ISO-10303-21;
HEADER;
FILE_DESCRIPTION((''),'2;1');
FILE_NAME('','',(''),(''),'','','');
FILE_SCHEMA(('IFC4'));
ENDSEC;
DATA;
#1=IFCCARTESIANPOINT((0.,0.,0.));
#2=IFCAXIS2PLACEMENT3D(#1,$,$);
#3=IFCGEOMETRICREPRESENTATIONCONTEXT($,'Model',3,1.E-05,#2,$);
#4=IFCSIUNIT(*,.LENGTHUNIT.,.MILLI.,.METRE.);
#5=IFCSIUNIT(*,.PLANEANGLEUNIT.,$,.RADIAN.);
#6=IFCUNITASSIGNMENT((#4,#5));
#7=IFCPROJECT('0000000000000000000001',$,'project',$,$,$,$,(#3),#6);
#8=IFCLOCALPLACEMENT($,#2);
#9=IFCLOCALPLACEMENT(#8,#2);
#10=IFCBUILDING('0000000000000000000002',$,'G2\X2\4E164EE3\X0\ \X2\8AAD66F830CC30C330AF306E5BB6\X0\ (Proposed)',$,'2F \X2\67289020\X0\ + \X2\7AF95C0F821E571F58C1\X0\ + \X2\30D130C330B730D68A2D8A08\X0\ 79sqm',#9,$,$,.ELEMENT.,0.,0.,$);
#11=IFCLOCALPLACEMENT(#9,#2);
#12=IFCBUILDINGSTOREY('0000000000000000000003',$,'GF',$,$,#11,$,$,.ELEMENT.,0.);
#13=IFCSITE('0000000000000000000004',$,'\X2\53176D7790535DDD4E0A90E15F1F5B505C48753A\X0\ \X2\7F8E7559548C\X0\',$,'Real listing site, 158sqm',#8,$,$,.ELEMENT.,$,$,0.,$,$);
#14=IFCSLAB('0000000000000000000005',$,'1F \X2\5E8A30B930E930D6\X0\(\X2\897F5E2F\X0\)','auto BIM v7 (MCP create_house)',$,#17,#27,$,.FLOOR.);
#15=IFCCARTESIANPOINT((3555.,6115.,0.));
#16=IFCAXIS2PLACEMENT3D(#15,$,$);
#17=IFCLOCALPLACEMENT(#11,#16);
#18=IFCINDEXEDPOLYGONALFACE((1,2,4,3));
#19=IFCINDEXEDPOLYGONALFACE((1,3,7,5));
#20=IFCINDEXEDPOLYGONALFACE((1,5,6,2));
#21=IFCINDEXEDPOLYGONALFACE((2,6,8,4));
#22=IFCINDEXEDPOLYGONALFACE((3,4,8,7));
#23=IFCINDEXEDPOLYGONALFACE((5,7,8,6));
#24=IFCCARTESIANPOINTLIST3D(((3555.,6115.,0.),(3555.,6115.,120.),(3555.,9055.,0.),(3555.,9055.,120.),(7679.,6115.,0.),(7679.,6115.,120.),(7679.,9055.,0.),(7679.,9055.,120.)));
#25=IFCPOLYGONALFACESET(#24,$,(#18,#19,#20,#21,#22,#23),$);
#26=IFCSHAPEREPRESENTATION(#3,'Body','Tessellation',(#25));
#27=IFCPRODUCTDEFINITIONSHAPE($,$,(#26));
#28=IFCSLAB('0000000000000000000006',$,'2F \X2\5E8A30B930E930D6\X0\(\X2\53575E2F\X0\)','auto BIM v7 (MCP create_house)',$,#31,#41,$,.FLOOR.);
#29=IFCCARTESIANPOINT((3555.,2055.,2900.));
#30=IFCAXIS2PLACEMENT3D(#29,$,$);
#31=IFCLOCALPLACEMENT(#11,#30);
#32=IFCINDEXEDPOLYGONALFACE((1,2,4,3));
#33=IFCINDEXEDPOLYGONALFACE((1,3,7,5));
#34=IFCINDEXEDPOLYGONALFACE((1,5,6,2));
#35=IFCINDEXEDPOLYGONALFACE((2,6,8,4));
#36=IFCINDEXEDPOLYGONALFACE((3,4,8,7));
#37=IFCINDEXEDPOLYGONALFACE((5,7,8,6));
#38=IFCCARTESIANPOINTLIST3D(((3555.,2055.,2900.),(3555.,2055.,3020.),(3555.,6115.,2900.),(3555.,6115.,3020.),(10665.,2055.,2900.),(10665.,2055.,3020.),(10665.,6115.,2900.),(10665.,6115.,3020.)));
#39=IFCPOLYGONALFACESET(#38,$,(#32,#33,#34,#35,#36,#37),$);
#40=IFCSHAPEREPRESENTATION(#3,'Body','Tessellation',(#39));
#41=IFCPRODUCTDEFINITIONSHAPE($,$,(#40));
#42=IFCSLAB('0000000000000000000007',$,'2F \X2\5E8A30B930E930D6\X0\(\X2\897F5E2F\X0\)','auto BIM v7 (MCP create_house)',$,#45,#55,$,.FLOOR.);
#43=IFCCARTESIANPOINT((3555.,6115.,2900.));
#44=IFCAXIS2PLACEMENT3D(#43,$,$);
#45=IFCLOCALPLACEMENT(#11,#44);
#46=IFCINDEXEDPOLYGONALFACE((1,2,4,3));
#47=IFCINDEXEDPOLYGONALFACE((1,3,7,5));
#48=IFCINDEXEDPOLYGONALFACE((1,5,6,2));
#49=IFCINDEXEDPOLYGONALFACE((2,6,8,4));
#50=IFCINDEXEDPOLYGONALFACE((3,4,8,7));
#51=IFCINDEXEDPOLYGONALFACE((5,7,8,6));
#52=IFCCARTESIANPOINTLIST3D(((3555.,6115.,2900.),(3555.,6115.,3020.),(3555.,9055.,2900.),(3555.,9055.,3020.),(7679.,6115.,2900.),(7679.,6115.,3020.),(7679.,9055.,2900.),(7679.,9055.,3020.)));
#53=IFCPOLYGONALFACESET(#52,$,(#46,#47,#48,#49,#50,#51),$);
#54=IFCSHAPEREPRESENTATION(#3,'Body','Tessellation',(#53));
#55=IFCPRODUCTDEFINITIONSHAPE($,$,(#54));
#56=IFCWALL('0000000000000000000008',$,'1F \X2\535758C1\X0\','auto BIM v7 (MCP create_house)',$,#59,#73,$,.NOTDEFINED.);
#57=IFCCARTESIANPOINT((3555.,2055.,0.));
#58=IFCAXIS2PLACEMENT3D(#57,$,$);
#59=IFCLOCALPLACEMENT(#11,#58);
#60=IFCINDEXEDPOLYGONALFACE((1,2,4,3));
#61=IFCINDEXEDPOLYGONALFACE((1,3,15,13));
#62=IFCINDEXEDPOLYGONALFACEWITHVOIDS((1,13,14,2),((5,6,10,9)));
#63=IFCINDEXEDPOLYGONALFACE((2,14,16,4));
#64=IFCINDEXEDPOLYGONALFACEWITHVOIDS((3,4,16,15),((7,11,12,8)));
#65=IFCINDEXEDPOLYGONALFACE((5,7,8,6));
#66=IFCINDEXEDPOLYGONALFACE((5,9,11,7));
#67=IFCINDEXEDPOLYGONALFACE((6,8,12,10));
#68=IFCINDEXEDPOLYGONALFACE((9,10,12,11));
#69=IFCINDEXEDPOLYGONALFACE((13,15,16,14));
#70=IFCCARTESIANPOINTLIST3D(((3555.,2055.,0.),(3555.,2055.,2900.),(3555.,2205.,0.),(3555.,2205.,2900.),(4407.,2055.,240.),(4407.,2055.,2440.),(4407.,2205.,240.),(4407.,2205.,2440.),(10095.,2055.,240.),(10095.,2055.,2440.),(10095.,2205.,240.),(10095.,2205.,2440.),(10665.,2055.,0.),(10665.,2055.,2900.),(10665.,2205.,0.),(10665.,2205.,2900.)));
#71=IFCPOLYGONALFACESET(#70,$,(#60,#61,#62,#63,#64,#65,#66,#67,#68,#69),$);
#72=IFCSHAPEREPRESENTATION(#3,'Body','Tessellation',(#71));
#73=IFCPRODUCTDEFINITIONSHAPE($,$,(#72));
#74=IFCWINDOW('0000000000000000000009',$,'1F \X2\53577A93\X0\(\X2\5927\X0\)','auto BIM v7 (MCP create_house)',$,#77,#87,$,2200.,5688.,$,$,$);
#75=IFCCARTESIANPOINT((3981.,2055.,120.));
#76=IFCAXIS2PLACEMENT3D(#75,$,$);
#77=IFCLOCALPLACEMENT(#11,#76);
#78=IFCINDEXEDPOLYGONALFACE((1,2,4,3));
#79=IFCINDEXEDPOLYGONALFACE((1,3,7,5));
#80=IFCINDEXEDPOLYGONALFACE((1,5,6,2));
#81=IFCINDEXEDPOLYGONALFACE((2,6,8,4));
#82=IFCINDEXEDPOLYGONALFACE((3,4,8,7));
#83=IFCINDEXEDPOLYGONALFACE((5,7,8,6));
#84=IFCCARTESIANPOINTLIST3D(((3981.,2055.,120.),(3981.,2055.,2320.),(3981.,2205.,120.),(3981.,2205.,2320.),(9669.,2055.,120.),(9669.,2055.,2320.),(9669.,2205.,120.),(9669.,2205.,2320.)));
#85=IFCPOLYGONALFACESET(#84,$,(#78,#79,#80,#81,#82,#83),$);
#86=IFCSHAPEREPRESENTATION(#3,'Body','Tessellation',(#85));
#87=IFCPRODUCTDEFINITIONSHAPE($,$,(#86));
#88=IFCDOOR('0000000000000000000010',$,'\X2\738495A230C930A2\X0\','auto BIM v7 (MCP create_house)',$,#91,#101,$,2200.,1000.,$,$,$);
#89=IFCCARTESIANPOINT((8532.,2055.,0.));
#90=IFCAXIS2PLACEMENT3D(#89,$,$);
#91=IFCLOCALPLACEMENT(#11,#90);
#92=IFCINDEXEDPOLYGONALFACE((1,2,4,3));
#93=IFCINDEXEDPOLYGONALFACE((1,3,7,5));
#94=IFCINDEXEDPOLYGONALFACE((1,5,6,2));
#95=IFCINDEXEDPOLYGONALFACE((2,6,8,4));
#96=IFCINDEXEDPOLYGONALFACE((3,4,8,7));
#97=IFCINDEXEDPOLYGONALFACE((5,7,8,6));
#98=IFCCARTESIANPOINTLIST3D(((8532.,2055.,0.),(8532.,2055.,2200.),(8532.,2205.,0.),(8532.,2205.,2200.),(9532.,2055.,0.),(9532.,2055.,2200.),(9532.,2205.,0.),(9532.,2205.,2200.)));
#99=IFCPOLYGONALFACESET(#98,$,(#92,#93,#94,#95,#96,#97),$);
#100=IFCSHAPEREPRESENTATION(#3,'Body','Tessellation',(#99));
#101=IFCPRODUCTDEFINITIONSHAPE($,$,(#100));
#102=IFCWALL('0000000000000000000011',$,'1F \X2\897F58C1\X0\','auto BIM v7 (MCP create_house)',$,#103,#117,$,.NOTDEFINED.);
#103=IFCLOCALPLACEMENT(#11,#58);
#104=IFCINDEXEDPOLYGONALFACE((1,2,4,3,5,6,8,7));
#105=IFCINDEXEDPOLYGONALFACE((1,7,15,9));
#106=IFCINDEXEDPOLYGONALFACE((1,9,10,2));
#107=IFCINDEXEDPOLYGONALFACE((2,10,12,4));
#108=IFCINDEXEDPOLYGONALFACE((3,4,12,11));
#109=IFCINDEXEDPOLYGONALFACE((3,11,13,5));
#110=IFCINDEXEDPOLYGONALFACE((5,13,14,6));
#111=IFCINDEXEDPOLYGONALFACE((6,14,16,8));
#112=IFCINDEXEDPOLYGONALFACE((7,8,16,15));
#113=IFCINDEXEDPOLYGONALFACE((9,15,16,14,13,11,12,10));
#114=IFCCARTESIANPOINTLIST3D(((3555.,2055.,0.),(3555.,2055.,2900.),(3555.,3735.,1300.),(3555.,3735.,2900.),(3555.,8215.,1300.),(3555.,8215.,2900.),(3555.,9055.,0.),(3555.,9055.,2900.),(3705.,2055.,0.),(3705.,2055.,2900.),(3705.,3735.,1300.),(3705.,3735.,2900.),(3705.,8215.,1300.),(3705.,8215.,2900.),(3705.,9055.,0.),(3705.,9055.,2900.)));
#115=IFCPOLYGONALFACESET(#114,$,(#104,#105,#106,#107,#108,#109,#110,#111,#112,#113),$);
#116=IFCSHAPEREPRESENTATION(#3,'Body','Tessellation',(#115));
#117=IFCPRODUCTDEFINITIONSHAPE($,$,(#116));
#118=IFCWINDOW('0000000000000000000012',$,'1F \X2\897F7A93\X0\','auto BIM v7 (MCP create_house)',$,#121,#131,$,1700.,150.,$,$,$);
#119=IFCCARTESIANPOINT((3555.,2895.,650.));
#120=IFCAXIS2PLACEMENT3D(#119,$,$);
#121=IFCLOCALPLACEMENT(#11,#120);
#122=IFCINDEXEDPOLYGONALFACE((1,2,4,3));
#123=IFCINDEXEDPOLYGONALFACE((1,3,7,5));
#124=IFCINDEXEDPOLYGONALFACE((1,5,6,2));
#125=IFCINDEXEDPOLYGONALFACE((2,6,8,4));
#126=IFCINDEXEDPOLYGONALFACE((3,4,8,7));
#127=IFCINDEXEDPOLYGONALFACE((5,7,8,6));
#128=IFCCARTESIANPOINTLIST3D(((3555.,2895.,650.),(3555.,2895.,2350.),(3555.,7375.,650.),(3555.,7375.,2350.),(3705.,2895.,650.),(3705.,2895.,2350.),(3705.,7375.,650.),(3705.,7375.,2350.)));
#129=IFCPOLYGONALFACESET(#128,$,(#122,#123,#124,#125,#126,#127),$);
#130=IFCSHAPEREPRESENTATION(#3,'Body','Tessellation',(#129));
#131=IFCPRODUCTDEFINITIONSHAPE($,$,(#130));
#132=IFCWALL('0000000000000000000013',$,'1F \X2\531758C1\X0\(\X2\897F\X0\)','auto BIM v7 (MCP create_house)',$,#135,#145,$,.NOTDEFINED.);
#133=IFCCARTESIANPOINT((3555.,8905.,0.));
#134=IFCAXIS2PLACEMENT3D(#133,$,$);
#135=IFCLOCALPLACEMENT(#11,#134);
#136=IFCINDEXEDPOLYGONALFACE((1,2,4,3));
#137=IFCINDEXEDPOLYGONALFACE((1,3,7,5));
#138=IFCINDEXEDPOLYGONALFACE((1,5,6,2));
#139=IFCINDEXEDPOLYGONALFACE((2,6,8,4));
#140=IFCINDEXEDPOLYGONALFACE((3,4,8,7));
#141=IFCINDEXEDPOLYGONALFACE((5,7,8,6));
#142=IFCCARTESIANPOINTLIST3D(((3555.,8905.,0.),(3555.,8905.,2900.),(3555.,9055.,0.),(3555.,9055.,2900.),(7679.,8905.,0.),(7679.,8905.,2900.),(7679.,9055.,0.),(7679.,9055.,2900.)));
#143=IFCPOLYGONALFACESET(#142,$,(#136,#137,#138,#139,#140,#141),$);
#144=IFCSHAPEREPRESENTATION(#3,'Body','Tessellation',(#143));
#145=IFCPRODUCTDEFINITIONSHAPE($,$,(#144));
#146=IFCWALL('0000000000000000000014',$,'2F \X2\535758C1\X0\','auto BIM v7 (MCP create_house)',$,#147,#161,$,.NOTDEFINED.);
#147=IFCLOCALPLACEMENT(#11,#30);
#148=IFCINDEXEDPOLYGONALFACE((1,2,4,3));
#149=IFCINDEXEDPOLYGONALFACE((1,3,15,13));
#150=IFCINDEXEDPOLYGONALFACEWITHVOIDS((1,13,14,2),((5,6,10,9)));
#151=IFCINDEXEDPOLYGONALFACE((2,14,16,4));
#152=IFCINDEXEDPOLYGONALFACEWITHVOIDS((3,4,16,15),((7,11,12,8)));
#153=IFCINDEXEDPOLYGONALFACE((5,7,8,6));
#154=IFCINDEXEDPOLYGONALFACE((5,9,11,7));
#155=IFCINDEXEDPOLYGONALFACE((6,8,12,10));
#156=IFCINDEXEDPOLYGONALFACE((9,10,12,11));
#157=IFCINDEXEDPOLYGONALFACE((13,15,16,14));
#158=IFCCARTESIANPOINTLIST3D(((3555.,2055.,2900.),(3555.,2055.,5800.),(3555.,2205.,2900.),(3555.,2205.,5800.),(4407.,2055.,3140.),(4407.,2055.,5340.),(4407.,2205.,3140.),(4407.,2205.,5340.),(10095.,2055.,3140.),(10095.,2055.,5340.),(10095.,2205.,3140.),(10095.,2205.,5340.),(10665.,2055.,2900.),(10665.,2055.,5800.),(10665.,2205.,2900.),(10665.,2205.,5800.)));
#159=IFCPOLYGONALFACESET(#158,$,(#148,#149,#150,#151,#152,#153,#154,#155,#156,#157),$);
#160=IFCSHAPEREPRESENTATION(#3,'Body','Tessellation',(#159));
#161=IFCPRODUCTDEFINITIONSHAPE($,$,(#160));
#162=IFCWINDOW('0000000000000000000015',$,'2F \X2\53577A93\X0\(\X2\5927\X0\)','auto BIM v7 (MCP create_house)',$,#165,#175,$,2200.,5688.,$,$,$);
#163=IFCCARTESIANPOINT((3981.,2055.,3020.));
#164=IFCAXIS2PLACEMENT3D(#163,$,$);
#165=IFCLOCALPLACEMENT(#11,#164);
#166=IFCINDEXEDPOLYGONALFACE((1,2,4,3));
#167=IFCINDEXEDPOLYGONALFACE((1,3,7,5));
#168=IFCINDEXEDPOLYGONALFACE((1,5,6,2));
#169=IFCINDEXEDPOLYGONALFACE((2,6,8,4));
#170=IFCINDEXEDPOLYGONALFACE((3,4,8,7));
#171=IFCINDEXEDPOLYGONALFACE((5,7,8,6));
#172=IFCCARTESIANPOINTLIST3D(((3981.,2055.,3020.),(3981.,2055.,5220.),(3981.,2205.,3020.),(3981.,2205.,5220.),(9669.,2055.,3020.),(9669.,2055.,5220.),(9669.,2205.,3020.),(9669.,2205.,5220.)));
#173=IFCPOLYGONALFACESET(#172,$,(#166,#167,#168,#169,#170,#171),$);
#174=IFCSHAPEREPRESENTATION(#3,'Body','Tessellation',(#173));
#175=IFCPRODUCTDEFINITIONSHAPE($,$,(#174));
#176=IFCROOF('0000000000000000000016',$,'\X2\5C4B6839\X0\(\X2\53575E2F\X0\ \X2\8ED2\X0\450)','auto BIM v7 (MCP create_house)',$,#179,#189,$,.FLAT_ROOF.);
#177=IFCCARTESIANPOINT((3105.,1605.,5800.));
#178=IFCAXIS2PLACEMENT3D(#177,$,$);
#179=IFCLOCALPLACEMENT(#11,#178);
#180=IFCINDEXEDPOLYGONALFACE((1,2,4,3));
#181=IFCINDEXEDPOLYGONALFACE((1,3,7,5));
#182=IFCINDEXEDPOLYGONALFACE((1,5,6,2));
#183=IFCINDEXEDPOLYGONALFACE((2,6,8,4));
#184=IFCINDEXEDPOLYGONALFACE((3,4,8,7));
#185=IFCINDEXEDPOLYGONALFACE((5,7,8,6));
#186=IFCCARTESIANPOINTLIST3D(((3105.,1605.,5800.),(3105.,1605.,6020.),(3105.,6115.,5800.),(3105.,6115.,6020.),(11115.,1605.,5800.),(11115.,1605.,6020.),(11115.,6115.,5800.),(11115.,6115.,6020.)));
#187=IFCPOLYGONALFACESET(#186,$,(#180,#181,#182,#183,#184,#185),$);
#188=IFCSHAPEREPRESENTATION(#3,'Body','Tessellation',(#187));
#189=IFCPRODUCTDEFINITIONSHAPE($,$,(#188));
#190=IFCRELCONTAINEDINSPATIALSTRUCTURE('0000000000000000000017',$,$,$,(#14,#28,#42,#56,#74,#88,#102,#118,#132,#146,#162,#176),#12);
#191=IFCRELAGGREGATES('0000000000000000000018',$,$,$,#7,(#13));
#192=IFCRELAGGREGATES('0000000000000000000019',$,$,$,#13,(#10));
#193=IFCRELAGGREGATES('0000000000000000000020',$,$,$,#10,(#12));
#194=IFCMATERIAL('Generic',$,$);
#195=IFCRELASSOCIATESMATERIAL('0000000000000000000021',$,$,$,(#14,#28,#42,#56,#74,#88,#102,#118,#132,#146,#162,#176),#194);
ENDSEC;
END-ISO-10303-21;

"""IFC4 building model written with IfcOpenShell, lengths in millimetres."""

from ifc_helpers import new_model, si_unit, frame, frame_2d, origin, place, context, project, spatial, rectangle, extrude, material, element, fill, save


model = new_model("IFC4")

# Units and contexts
model_context = context("Model", 3, precision=1e-05, world=origin())
ifc_project = project(units=[si_unit("LENGTHUNIT", "METRE", prefix="MILLI"), si_unit("PLANEANGLEUNIT", "RADIAN")], contexts=[model_context])

# Site, building, storey
site_placement = place(None, origin())
site = spatial("IfcSite", under=ifc_project, at=site_placement, Name="北海道川上郡弟子屈町 美留和", ObjectType="Real listing site, 158sqm", CompositionType="ELEMENT", RefElevation=0.0)
building_placement = place(site_placement, origin())
building = spatial("IfcBuilding", under=site, at=building_placement, Name="G2世代 読書ヌックの家 (Proposed)", ObjectType="2F 木造 + 竹小舞土壁 + パッシブ設計 79sqm", CompositionType="ELEMENT", ElevationOfRefHeight=0.0, ElevationOfTerrain=0.0)
storey_placement = place(building_placement, origin())
storey = spatial("IfcBuildingStorey", under=building, at=storey_placement, Name="GF", CompositionType="ELEMENT", Elevation=0.0)

# Slabs
ifc_material = material(Name="Generic")
slab_1_placement = place(storey_placement, frame((3555.0, 6115.0, 0.0)))
element("IfcSlab", 1, at=slab_1_placement, inside=storey, material=ifc_material, Name="1F 床スラブ(西帯)", Description="auto BIM v7 (MCP create_house)", PredefinedType="FLOOR", context=model_context, shape_type="SweptSolid", body=[
    extrude(rectangle(XDim=4124.0, YDim=2940.0, at=frame_2d((2062.0, 1470.0))), frame((3555.0, 6115.0, 0.0)), (0.0, 0.0, 1.0), 120.0),
])
slab_2_placement = place(storey_placement, frame((3555.0, 2055.0, 2900.0)))
element("IfcSlab", 2, at=slab_2_placement, inside=storey, material=ifc_material, Name="2F 床スラブ(南帯)", Description="auto BIM v7 (MCP create_house)", PredefinedType="FLOOR", context=model_context, shape_type="SweptSolid", body=[
    extrude(rectangle(XDim=7110.0, YDim=4060.0, at=frame_2d((3555.0, 2030.0))), frame((3555.0, 2055.0, 2900.0)), (0.0, 0.0, 1.0), 120.0),
])
slab_3_placement = place(storey_placement, frame((3555.0, 6115.0, 2900.0)))
element("IfcSlab", 3, at=slab_3_placement, inside=storey, material=ifc_material, Name="2F 床スラブ(西帯)", Description="auto BIM v7 (MCP create_house)", PredefinedType="FLOOR", context=model_context, shape_type="SweptSolid", body=[
    extrude(rectangle(XDim=4124.0, YDim=2940.0, at=frame_2d((2062.0, 1470.0))), frame((3555.0, 6115.0, 2900.0)), (0.0, 0.0, 1.0), 120.0),
])

# Wall, openings, window, door
wall_1_placement = place(storey_placement, frame((3555.0, 2055.0, 0.0)))
wall_1 = element("IfcWall", 4, at=wall_1_placement, inside=storey, material=ifc_material, Name="1F 南壁", Description="auto BIM v7 (MCP create_house)", PredefinedType="NOTDEFINED", context=model_context, shape_type="SweptSolid", body=[
    extrude(rectangle(XDim=7110.0, YDim=150.0, at=frame_2d((3555.0, 75.0))), frame((3555.0, 2055.0, 0.0)), (0.0, 0.0, 1.0), 2900.0),
])
opening_1_placement = place(storey_placement, frame((3981.0, 2055.0, 120.0)))
opening_1 = element("IfcOpeningElement", 5, at=opening_1_placement, cuts=wall_1, PredefinedType="NOTDEFINED", context=model_context, shape_type="SweptSolid", body=[
    extrude(rectangle(XDim=5688.0, YDim=150.0, at=frame_2d((2844.0, 75.0))), frame((3981.0, 2055.0, 120.0)), (0.0, 0.0, 1.0), 2200.0),
])
opening_2_placement = place(storey_placement, frame((8532.0, 2055.0, 0.0)))
opening_2 = element("IfcOpeningElement", 6, at=opening_2_placement, cuts=wall_1, PredefinedType="NOTDEFINED", context=model_context, shape_type="SweptSolid", body=[
    extrude(rectangle(XDim=1000.0, YDim=150.0, at=frame_2d((500.0, 75.0))), frame((8532.0, 2055.0, 0.0)), (0.0, 0.0, 1.0), 2200.0),
])
window_1_placement = place(storey_placement, frame((3981.0, 2055.0, 120.0)))
window_1 = element("IfcWindow", 7, at=window_1_placement, inside=storey, material=ifc_material, Name="1F 南窓(大)", Description="auto BIM v7 (MCP create_house)", OverallHeight=2200.0, OverallWidth=5688.0, context=model_context, shape_type="SweptSolid", body=[
    extrude(rectangle(XDim=5688.0, YDim=150.0, at=frame_2d((2844.0, 75.0))), frame((3981.0, 2055.0, 120.0)), (0.0, 0.0, 1.0), 2200.0),
])
fill(opening_1, window_1)
door_placement = place(storey_placement, frame((8532.0, 2055.0, 0.0)))
door = element("IfcDoor", 8, at=door_placement, inside=storey, material=ifc_material, Name="玄関ドア", Description="auto BIM v7 (MCP create_house)", OverallHeight=2200.0, OverallWidth=1000.0, context=model_context, shape_type="SweptSolid", body=[
    extrude(rectangle(XDim=1000.0, YDim=150.0, at=frame_2d((500.0, 75.0))), frame((8532.0, 2055.0, 0.0)), (0.0, 0.0, 1.0), 2200.0),
])
fill(opening_2, door)

# Wall, opening, window
wall_2_placement = place(storey_placement, frame((3555.0, 2055.0, 0.0)))
wall_2 = element("IfcWall", 9, at=wall_2_placement, inside=storey, material=ifc_material, Name="1F 西壁", Description="auto BIM v7 (MCP create_house)", PredefinedType="NOTDEFINED", context=model_context, shape_type="SweptSolid", body=[
    extrude(rectangle(XDim=150.0, YDim=7000.0, at=frame_2d((75.0, 3500.0))), frame((3555.0, 2055.0, 0.0)), (0.0, 0.0, 1.0), 2900.0),
])
opening_3_placement = place(storey_placement, frame((3555.0, 2895.0, 650.0)))
opening_3 = element("IfcOpeningElement", 10, at=opening_3_placement, cuts=wall_2, PredefinedType="NOTDEFINED", context=model_context, shape_type="SweptSolid", body=[
    extrude(rectangle(XDim=150.0, YDim=4480.0, at=frame_2d((75.0, 2240.0))), frame((3555.0, 2895.0, 650.0)), (0.0, 0.0, 1.0), 1700.0),
])
window_2_placement = place(storey_placement, frame((3555.0, 2895.0, 650.0)))
window_2 = element("IfcWindow", 11, at=window_2_placement, inside=storey, material=ifc_material, Name="1F 西窓", Description="auto BIM v7 (MCP create_house)", OverallHeight=1700.0, OverallWidth=150.0, context=model_context, shape_type="SweptSolid", body=[
    extrude(rectangle(XDim=150.0, YDim=4480.0, at=frame_2d((75.0, 2240.0))), frame((3555.0, 2895.0, 650.0)), (0.0, 0.0, 1.0), 1700.0),
])
fill(opening_3, window_2)

# Wall
wall_3_placement = place(storey_placement, frame((3555.0, 8905.0, 0.0)))
element("IfcWall", 12, at=wall_3_placement, inside=storey, material=ifc_material, Name="1F 北壁(西)", Description="auto BIM v7 (MCP create_house)", PredefinedType="NOTDEFINED", context=model_context, shape_type="SweptSolid", body=[
    extrude(rectangle(XDim=4124.0, YDim=150.0, at=frame_2d((2062.0, 75.0))), frame((3555.0, 8905.0, 0.0)), (0.0, 0.0, 1.0), 2900.0),
])

# Wall, opening, window
wall_4_placement = place(storey_placement, frame((3555.0, 2055.0, 2900.0)))
wall_4 = element("IfcWall", 13, at=wall_4_placement, inside=storey, material=ifc_material, Name="2F 南壁", Description="auto BIM v7 (MCP create_house)", PredefinedType="NOTDEFINED", context=model_context, shape_type="SweptSolid", body=[
    extrude(rectangle(XDim=7110.0, YDim=150.0, at=frame_2d((3555.0, 75.0))), frame((3555.0, 2055.0, 2900.0)), (0.0, 0.0, 1.0), 2900.0),
])
opening_4_placement = place(storey_placement, frame((3981.0, 2055.0, 3020.0)))
opening_4 = element("IfcOpeningElement", 14, at=opening_4_placement, cuts=wall_4, PredefinedType="NOTDEFINED", context=model_context, shape_type="SweptSolid", body=[
    extrude(rectangle(XDim=5688.0, YDim=150.0, at=frame_2d((2844.0, 75.0))), frame((3981.0, 2055.0, 3020.0)), (0.0, 0.0, 1.0), 2200.0),
])
window_3_placement = place(storey_placement, frame((3981.0, 2055.0, 3020.0)))
window_3 = element("IfcWindow", 15, at=window_3_placement, inside=storey, material=ifc_material, Name="2F 南窓(大)", Description="auto BIM v7 (MCP create_house)", OverallHeight=2200.0, OverallWidth=5688.0, context=model_context, shape_type="SweptSolid", body=[
    extrude(rectangle(XDim=5688.0, YDim=150.0, at=frame_2d((2844.0, 75.0))), frame((3981.0, 2055.0, 3020.0)), (0.0, 0.0, 1.0), 2200.0),
])
fill(opening_4, window_3)

# Roof
roof_1_placement = place(storey_placement, frame((3105.0, 1605.0, 5800.0)))
element("IfcRoof", 16, at=roof_1_placement, inside=storey, material=ifc_material, Name="屋根(南帯 軒450)", Description="auto BIM v7 (MCP create_house)", PredefinedType="FLAT_ROOF", context=model_context, shape_type="SweptSolid", body=[
    extrude(rectangle(XDim=8010.0, YDim=4510.0, at=frame_2d((4005.0, 2255.0))), frame((3105.0, 1605.0, 5800.0)), (0.0, 0.0, 1.0), 220.0),
])

save(model, "model.ifc")
